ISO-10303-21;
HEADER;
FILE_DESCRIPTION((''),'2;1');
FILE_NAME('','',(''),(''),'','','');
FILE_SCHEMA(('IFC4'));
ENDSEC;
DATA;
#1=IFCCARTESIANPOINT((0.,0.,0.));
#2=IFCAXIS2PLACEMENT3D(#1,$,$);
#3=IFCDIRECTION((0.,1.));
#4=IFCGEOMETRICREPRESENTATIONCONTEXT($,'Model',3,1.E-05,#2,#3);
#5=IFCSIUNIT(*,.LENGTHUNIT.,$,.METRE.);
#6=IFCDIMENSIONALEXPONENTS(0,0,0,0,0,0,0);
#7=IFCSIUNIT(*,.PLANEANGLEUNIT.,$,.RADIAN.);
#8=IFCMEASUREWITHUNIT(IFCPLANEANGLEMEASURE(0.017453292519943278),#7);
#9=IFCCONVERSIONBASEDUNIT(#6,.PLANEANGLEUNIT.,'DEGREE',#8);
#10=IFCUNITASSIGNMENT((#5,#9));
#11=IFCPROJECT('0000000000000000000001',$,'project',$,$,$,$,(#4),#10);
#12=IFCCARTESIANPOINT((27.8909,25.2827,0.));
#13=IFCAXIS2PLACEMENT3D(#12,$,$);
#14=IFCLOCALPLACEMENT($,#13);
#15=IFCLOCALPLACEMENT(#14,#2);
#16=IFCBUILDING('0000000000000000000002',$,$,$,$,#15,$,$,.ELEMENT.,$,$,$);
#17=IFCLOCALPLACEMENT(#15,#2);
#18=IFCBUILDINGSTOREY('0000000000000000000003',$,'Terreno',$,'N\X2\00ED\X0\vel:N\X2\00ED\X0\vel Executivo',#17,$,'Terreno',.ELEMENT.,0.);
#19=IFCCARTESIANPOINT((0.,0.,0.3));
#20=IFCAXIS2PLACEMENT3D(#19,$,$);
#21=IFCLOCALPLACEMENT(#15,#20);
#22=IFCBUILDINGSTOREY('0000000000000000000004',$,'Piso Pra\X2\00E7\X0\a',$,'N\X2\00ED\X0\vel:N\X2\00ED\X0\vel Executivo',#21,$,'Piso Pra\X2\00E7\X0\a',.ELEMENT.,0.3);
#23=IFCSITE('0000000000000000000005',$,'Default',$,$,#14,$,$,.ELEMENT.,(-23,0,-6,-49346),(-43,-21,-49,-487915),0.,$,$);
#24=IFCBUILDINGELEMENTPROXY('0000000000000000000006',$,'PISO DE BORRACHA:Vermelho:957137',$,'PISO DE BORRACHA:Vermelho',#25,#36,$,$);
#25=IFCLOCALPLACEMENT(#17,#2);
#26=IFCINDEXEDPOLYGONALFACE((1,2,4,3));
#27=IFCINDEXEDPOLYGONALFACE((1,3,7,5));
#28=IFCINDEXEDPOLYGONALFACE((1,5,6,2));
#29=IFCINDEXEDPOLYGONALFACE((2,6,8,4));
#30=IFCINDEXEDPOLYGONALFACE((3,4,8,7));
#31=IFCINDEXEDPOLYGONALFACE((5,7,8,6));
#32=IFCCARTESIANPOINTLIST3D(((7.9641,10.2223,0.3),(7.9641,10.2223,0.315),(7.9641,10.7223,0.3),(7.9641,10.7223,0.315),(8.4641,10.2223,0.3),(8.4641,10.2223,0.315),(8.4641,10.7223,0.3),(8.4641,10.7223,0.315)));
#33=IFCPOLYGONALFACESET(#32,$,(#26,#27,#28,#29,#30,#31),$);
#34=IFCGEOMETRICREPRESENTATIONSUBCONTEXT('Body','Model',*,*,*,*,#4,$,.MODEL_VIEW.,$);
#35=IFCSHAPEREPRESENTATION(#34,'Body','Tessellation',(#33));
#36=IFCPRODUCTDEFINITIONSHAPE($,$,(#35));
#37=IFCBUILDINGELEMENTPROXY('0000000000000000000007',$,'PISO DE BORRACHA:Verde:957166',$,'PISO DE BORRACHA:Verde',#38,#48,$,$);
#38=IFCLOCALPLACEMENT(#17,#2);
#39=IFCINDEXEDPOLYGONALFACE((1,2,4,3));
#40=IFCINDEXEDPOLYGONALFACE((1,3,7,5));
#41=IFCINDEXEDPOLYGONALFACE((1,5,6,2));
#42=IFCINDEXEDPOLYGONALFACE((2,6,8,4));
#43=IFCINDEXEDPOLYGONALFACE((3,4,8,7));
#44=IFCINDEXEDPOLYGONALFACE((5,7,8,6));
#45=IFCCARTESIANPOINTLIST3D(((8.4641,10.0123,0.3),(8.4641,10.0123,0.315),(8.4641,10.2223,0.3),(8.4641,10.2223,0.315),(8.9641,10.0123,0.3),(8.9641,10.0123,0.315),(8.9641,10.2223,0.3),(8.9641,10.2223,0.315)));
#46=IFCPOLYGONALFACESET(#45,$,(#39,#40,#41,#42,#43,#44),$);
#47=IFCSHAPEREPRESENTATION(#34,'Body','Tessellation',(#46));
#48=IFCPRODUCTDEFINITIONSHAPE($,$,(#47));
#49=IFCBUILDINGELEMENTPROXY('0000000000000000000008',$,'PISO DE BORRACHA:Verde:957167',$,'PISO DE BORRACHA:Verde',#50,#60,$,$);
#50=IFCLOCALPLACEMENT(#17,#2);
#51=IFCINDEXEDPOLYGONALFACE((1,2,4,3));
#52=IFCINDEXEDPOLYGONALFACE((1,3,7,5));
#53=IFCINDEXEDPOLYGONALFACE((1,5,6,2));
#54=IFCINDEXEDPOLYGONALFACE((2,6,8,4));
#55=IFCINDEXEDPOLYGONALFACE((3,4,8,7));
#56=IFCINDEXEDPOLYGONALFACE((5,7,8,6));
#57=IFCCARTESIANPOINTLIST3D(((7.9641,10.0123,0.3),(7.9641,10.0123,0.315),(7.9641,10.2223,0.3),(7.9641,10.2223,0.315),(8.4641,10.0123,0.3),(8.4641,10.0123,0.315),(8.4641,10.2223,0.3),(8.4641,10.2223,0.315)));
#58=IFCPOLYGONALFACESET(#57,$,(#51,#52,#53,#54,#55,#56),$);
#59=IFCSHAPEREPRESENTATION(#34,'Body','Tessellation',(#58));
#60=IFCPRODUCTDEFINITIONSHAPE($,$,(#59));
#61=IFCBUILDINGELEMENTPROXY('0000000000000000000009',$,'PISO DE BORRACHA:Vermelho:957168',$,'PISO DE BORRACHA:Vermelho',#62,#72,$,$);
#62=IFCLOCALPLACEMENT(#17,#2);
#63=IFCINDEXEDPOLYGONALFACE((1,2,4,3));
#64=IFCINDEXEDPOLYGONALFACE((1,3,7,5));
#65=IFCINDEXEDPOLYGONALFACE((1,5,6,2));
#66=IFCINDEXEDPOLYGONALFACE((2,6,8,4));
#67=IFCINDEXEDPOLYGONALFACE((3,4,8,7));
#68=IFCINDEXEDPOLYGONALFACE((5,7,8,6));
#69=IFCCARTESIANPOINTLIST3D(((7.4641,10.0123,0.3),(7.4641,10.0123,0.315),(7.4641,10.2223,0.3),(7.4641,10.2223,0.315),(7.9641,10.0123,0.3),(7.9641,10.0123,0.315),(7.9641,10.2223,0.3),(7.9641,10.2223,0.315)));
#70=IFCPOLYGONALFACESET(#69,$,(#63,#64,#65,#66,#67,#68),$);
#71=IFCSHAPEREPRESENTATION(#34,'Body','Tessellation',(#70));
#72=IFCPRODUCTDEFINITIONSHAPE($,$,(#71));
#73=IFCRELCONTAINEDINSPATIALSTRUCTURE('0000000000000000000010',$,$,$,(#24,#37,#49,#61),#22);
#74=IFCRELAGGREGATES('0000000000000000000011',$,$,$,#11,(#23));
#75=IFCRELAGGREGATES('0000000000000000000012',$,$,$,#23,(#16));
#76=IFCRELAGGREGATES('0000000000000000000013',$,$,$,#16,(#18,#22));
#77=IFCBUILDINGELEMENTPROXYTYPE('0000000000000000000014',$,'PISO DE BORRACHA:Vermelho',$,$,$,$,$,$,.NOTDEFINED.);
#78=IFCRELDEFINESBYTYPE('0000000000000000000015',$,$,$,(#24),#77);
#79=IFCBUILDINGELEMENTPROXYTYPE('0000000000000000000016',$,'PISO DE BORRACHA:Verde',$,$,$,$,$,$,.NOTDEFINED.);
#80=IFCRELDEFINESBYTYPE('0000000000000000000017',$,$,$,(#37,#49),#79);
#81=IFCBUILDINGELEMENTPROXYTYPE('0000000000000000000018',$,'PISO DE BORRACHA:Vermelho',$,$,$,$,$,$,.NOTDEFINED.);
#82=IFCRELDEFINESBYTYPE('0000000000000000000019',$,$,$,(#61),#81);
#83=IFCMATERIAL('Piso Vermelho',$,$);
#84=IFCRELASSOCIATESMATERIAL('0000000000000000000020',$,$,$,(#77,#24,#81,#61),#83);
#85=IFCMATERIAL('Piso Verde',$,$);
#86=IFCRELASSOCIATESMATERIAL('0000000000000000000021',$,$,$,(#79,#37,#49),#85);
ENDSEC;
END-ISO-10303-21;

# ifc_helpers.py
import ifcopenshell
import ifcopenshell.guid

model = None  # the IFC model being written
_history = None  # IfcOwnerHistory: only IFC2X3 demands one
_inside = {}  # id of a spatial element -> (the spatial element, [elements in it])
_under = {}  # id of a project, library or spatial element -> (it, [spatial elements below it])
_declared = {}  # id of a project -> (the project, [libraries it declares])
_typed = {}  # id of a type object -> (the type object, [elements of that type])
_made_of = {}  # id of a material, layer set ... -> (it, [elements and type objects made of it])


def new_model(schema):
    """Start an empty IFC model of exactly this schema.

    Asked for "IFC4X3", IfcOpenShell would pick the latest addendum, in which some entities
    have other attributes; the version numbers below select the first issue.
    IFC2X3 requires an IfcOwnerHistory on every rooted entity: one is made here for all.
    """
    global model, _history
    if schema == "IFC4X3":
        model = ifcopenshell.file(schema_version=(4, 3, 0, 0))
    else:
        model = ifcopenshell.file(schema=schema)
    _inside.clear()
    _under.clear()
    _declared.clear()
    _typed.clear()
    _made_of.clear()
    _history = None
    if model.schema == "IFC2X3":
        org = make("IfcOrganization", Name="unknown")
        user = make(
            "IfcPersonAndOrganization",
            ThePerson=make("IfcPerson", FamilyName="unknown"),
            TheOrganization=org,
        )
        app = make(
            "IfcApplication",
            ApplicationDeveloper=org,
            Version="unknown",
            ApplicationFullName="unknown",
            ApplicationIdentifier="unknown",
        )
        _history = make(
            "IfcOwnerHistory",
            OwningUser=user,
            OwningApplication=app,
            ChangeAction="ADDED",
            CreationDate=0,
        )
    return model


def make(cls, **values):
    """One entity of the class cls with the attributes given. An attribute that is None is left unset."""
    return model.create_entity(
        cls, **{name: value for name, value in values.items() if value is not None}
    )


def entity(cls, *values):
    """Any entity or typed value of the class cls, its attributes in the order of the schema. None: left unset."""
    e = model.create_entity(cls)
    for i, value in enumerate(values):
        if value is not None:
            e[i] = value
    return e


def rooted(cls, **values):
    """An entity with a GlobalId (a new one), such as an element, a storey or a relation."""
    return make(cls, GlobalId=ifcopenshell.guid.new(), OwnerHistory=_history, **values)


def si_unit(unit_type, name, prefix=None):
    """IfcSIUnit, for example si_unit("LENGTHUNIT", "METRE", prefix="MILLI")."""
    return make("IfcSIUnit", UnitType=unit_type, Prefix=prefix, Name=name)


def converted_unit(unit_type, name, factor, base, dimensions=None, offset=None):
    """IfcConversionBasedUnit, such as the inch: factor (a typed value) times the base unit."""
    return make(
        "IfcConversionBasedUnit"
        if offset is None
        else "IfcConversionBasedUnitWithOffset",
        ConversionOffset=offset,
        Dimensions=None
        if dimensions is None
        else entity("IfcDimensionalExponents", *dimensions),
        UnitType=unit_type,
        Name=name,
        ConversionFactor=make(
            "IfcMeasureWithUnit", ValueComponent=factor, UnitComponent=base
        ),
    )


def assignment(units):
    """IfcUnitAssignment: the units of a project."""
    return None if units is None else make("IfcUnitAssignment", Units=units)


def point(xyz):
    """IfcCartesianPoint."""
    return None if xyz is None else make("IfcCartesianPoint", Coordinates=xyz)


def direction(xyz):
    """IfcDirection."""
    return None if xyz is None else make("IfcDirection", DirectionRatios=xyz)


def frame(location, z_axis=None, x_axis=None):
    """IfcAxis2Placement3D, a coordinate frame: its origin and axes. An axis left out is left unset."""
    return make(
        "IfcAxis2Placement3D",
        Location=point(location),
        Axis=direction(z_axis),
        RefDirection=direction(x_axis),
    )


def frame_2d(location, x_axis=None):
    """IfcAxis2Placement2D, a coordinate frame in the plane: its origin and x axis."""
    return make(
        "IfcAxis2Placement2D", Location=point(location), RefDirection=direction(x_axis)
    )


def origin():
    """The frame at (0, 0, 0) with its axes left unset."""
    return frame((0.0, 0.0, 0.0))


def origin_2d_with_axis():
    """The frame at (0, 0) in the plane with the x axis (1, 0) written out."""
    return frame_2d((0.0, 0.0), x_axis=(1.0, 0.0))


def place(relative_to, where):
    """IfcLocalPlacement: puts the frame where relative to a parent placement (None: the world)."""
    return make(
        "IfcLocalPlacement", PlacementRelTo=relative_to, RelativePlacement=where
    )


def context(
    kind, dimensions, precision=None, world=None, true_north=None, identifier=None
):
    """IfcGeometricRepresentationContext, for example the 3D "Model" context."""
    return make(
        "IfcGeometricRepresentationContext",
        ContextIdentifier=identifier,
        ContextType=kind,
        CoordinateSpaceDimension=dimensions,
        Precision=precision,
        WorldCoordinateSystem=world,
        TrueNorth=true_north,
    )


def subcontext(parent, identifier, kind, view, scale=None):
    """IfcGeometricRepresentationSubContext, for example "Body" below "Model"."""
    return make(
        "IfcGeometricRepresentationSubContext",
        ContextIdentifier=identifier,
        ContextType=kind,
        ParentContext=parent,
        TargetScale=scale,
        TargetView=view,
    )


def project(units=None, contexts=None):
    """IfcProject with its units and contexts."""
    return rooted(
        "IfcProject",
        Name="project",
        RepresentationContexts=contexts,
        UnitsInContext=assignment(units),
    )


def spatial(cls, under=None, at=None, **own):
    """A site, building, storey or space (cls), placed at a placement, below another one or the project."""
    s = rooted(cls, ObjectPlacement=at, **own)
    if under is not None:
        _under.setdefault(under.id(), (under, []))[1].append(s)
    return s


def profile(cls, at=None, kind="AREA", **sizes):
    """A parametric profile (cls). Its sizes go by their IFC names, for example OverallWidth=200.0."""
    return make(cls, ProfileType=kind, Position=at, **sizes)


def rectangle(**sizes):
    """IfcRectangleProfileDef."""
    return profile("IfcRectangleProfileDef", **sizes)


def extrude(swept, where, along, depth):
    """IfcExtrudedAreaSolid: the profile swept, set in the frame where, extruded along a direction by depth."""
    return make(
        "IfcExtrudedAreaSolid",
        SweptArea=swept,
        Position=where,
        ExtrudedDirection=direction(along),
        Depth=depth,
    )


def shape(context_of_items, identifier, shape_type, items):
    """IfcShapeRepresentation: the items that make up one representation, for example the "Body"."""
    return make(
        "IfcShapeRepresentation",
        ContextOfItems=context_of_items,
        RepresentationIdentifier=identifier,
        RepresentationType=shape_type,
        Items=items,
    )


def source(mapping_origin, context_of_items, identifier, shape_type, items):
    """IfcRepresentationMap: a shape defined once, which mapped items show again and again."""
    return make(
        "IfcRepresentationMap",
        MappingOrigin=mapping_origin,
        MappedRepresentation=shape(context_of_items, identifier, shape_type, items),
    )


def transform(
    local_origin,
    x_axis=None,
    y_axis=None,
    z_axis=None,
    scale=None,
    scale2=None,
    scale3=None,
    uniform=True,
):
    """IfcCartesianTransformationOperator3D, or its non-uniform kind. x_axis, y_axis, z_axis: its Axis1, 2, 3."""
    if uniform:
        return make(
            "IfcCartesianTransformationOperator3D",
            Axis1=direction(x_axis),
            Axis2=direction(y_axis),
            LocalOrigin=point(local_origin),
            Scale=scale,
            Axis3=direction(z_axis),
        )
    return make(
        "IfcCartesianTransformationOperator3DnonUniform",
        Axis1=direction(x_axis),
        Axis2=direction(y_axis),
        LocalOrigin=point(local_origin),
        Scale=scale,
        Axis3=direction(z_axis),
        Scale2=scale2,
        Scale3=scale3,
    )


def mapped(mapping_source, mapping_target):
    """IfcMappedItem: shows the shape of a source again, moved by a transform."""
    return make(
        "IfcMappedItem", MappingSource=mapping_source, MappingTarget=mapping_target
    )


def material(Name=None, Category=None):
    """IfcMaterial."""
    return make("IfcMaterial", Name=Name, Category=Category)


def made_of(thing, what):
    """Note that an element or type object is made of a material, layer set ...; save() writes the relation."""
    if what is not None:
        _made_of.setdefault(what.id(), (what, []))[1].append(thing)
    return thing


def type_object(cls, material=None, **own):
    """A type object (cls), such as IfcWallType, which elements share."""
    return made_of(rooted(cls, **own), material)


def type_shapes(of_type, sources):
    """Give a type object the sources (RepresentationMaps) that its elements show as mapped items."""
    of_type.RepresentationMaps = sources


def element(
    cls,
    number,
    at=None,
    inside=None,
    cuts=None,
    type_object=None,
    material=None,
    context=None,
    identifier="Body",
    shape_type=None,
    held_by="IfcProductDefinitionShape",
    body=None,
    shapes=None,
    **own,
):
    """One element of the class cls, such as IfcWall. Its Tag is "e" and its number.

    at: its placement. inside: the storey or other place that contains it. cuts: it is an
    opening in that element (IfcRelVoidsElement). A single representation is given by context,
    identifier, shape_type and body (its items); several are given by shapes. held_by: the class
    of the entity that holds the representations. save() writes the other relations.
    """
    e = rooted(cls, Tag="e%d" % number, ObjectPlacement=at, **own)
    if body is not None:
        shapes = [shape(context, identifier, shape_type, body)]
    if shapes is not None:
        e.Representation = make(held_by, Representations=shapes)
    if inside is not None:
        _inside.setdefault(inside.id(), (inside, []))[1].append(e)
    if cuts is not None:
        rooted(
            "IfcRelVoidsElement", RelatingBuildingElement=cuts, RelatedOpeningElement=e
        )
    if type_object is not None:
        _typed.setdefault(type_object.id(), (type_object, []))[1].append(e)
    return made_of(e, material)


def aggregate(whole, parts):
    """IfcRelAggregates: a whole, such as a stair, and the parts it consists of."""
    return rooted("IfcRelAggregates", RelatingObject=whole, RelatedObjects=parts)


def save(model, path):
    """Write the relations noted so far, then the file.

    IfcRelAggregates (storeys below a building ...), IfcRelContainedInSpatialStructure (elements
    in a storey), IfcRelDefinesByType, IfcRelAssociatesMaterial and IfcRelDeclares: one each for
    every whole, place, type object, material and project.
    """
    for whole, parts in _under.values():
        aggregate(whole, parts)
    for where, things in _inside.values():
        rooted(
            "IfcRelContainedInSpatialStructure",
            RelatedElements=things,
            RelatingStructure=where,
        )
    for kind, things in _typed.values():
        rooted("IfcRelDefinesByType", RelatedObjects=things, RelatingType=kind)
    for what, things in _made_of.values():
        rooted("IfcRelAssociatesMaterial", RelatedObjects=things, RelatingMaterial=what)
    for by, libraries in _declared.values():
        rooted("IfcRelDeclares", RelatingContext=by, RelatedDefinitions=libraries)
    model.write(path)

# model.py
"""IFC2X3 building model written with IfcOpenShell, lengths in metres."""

from ifc_helpers import new_model, entity, si_unit, converted_unit, direction, frame, origin, origin_2d_with_axis, place, context, subcontext, project, spatial, rectangle, extrude, source, transform, mapped, material, type_object, type_shapes, element, save


model = new_model("IFC2X3")

# Units and contexts
model_context = context("Model", 3, precision=1e-05, world=origin(), true_north=direction((0.0, 1.0)))
body_context = subcontext(model_context, "Body", "Model", "MODEL_VIEW")
ifc_project = project(units=[si_unit("LENGTHUNIT", "METRE"), converted_unit("PLANEANGLEUNIT", "DEGREE", entity("IfcPlaneAngleMeasure", 0.017453292519943278), si_unit("PLANEANGLEUNIT", "RADIAN"), dimensions=[0, 0, 0, 0, 0, 0, 0])], contexts=[model_context])

# Site, building, storey
site_placement = place(None, frame((27.8909, 25.2827, 0.0)))
site = spatial("IfcSite", under=ifc_project, at=site_placement, Name="Default", CompositionType="ELEMENT", RefLatitude=(-23, 0, -6, -49346), RefLongitude=(-43, -21, -49, -487915), RefElevation=0.0)
building_placement = place(site_placement, origin())
building = spatial("IfcBuilding", under=site, at=building_placement, CompositionType="ELEMENT")
storey_1_placement = place(building_placement, origin())
storey_1 = spatial("IfcBuildingStorey", under=building, at=storey_1_placement, Name="Terreno", ObjectType="Nível:Nível Executivo", LongName="Terreno", CompositionType="ELEMENT", Elevation=0.0)

# Shared definitions
storey_2_placement = place(building_placement, frame((0.0, 0.0, 0.3)))
storey_2 = spatial("IfcBuildingStorey", under=building, at=storey_2_placement, Name="Piso Praça", ObjectType="Nível:Nível Executivo", LongName="Piso Praça", CompositionType="ELEMENT", Elevation=0.3)

# Building element proxies
ifc_material_1 = material(Name="Piso Verde")
ifc_material_2 = material(Name="Piso Vermelho")
building_element_proxy_type_1 = type_object("IfcBuildingElementProxyType", Name="PISO DE BORRACHA:Vermelho", PredefinedType="NOTDEFINED", material=ifc_material_2)
shared_shape_1 = source(origin(), body_context, "Body", "SweptSolid", [
    extrude(rectangle(XDim=0.5, YDim=0.5, at=origin_2d_with_axis()), frame((0.25, 0.25, 0.0), z_axis=(0.0, 0.0, 1.0), x_axis=(-1.0, 0.0, 0.0)), (0.0, 0.0, 1.0), 0.015),
])
type_shapes(building_element_proxy_type_1, [shared_shape_1])
proxy_1_placement = place(storey_2_placement, frame((7.9641, 10.2223, 0.0)))
element("IfcBuildingElementProxy", 1, at=proxy_1_placement, inside=storey_2, type_object=building_element_proxy_type_1, material=ifc_material_2, Name="PISO DE BORRACHA:Vermelho:957137", ObjectType="PISO DE BORRACHA:Vermelho", context=body_context, shape_type="MappedRepresentation", body=[
    mapped(shared_shape_1, transform((0.0, 0.0, 0.0), scale=1.0)),
])
building_element_proxy_type_2 = type_object("IfcBuildingElementProxyType", Name="PISO DE BORRACHA:Verde", PredefinedType="NOTDEFINED", material=ifc_material_1)
shared_shape_2 = source(origin(), body_context, "Body", "SweptSolid", [
    extrude(rectangle(XDim=0.5, YDim=0.21, at=origin_2d_with_axis()), frame((0.25, 0.105, 0.0), z_axis=(0.0, 0.0, 1.0), x_axis=(-1.0, 0.0, 0.0)), (0.0, 0.0, 1.0), 0.015),
])
type_shapes(building_element_proxy_type_2, [shared_shape_2])
for number, where, name in (
    (2, (8.4641, 10.0123, 0.0), "PISO DE BORRACHA:Verde:957166"),
    (3, (7.9641, 10.0123, 0.0), "PISO DE BORRACHA:Verde:957167"),
):
    element("IfcBuildingElementProxy", number, at=place(storey_2_placement, frame(where)), inside=storey_2, type_object=building_element_proxy_type_2, material=ifc_material_1, Name=name, ObjectType="PISO DE BORRACHA:Verde", context=body_context, shape_type="MappedRepresentation", body=[
        mapped(shared_shape_2, transform((0.0, 0.0, 0.0), scale=1.0)),
    ])
building_element_proxy_type_3 = type_object("IfcBuildingElementProxyType", Name="PISO DE BORRACHA:Vermelho", PredefinedType="NOTDEFINED", material=ifc_material_2)
shared_shape_3 = source(origin(), body_context, "Body", "SweptSolid", [
    extrude(rectangle(XDim=0.5, YDim=0.21, at=origin_2d_with_axis()), frame((0.25, 0.105, 0.0), z_axis=(0.0, 0.0, 1.0), x_axis=(-1.0, 0.0, 0.0)), (0.0, 0.0, 1.0), 0.015),
])
type_shapes(building_element_proxy_type_3, [shared_shape_3])
proxy_2_placement = place(storey_2_placement, frame((7.4641, 10.0123, 0.0)))
element("IfcBuildingElementProxy", 4, at=proxy_2_placement, inside=storey_2, type_object=building_element_proxy_type_3, material=ifc_material_2, Name="PISO DE BORRACHA:Vermelho:957168", ObjectType="PISO DE BORRACHA:Vermelho", context=body_context, shape_type="MappedRepresentation", body=[
    mapped(shared_shape_3, transform((0.0, 0.0, 0.0), scale=1.0)),
])

save(model, "model.ifc")
